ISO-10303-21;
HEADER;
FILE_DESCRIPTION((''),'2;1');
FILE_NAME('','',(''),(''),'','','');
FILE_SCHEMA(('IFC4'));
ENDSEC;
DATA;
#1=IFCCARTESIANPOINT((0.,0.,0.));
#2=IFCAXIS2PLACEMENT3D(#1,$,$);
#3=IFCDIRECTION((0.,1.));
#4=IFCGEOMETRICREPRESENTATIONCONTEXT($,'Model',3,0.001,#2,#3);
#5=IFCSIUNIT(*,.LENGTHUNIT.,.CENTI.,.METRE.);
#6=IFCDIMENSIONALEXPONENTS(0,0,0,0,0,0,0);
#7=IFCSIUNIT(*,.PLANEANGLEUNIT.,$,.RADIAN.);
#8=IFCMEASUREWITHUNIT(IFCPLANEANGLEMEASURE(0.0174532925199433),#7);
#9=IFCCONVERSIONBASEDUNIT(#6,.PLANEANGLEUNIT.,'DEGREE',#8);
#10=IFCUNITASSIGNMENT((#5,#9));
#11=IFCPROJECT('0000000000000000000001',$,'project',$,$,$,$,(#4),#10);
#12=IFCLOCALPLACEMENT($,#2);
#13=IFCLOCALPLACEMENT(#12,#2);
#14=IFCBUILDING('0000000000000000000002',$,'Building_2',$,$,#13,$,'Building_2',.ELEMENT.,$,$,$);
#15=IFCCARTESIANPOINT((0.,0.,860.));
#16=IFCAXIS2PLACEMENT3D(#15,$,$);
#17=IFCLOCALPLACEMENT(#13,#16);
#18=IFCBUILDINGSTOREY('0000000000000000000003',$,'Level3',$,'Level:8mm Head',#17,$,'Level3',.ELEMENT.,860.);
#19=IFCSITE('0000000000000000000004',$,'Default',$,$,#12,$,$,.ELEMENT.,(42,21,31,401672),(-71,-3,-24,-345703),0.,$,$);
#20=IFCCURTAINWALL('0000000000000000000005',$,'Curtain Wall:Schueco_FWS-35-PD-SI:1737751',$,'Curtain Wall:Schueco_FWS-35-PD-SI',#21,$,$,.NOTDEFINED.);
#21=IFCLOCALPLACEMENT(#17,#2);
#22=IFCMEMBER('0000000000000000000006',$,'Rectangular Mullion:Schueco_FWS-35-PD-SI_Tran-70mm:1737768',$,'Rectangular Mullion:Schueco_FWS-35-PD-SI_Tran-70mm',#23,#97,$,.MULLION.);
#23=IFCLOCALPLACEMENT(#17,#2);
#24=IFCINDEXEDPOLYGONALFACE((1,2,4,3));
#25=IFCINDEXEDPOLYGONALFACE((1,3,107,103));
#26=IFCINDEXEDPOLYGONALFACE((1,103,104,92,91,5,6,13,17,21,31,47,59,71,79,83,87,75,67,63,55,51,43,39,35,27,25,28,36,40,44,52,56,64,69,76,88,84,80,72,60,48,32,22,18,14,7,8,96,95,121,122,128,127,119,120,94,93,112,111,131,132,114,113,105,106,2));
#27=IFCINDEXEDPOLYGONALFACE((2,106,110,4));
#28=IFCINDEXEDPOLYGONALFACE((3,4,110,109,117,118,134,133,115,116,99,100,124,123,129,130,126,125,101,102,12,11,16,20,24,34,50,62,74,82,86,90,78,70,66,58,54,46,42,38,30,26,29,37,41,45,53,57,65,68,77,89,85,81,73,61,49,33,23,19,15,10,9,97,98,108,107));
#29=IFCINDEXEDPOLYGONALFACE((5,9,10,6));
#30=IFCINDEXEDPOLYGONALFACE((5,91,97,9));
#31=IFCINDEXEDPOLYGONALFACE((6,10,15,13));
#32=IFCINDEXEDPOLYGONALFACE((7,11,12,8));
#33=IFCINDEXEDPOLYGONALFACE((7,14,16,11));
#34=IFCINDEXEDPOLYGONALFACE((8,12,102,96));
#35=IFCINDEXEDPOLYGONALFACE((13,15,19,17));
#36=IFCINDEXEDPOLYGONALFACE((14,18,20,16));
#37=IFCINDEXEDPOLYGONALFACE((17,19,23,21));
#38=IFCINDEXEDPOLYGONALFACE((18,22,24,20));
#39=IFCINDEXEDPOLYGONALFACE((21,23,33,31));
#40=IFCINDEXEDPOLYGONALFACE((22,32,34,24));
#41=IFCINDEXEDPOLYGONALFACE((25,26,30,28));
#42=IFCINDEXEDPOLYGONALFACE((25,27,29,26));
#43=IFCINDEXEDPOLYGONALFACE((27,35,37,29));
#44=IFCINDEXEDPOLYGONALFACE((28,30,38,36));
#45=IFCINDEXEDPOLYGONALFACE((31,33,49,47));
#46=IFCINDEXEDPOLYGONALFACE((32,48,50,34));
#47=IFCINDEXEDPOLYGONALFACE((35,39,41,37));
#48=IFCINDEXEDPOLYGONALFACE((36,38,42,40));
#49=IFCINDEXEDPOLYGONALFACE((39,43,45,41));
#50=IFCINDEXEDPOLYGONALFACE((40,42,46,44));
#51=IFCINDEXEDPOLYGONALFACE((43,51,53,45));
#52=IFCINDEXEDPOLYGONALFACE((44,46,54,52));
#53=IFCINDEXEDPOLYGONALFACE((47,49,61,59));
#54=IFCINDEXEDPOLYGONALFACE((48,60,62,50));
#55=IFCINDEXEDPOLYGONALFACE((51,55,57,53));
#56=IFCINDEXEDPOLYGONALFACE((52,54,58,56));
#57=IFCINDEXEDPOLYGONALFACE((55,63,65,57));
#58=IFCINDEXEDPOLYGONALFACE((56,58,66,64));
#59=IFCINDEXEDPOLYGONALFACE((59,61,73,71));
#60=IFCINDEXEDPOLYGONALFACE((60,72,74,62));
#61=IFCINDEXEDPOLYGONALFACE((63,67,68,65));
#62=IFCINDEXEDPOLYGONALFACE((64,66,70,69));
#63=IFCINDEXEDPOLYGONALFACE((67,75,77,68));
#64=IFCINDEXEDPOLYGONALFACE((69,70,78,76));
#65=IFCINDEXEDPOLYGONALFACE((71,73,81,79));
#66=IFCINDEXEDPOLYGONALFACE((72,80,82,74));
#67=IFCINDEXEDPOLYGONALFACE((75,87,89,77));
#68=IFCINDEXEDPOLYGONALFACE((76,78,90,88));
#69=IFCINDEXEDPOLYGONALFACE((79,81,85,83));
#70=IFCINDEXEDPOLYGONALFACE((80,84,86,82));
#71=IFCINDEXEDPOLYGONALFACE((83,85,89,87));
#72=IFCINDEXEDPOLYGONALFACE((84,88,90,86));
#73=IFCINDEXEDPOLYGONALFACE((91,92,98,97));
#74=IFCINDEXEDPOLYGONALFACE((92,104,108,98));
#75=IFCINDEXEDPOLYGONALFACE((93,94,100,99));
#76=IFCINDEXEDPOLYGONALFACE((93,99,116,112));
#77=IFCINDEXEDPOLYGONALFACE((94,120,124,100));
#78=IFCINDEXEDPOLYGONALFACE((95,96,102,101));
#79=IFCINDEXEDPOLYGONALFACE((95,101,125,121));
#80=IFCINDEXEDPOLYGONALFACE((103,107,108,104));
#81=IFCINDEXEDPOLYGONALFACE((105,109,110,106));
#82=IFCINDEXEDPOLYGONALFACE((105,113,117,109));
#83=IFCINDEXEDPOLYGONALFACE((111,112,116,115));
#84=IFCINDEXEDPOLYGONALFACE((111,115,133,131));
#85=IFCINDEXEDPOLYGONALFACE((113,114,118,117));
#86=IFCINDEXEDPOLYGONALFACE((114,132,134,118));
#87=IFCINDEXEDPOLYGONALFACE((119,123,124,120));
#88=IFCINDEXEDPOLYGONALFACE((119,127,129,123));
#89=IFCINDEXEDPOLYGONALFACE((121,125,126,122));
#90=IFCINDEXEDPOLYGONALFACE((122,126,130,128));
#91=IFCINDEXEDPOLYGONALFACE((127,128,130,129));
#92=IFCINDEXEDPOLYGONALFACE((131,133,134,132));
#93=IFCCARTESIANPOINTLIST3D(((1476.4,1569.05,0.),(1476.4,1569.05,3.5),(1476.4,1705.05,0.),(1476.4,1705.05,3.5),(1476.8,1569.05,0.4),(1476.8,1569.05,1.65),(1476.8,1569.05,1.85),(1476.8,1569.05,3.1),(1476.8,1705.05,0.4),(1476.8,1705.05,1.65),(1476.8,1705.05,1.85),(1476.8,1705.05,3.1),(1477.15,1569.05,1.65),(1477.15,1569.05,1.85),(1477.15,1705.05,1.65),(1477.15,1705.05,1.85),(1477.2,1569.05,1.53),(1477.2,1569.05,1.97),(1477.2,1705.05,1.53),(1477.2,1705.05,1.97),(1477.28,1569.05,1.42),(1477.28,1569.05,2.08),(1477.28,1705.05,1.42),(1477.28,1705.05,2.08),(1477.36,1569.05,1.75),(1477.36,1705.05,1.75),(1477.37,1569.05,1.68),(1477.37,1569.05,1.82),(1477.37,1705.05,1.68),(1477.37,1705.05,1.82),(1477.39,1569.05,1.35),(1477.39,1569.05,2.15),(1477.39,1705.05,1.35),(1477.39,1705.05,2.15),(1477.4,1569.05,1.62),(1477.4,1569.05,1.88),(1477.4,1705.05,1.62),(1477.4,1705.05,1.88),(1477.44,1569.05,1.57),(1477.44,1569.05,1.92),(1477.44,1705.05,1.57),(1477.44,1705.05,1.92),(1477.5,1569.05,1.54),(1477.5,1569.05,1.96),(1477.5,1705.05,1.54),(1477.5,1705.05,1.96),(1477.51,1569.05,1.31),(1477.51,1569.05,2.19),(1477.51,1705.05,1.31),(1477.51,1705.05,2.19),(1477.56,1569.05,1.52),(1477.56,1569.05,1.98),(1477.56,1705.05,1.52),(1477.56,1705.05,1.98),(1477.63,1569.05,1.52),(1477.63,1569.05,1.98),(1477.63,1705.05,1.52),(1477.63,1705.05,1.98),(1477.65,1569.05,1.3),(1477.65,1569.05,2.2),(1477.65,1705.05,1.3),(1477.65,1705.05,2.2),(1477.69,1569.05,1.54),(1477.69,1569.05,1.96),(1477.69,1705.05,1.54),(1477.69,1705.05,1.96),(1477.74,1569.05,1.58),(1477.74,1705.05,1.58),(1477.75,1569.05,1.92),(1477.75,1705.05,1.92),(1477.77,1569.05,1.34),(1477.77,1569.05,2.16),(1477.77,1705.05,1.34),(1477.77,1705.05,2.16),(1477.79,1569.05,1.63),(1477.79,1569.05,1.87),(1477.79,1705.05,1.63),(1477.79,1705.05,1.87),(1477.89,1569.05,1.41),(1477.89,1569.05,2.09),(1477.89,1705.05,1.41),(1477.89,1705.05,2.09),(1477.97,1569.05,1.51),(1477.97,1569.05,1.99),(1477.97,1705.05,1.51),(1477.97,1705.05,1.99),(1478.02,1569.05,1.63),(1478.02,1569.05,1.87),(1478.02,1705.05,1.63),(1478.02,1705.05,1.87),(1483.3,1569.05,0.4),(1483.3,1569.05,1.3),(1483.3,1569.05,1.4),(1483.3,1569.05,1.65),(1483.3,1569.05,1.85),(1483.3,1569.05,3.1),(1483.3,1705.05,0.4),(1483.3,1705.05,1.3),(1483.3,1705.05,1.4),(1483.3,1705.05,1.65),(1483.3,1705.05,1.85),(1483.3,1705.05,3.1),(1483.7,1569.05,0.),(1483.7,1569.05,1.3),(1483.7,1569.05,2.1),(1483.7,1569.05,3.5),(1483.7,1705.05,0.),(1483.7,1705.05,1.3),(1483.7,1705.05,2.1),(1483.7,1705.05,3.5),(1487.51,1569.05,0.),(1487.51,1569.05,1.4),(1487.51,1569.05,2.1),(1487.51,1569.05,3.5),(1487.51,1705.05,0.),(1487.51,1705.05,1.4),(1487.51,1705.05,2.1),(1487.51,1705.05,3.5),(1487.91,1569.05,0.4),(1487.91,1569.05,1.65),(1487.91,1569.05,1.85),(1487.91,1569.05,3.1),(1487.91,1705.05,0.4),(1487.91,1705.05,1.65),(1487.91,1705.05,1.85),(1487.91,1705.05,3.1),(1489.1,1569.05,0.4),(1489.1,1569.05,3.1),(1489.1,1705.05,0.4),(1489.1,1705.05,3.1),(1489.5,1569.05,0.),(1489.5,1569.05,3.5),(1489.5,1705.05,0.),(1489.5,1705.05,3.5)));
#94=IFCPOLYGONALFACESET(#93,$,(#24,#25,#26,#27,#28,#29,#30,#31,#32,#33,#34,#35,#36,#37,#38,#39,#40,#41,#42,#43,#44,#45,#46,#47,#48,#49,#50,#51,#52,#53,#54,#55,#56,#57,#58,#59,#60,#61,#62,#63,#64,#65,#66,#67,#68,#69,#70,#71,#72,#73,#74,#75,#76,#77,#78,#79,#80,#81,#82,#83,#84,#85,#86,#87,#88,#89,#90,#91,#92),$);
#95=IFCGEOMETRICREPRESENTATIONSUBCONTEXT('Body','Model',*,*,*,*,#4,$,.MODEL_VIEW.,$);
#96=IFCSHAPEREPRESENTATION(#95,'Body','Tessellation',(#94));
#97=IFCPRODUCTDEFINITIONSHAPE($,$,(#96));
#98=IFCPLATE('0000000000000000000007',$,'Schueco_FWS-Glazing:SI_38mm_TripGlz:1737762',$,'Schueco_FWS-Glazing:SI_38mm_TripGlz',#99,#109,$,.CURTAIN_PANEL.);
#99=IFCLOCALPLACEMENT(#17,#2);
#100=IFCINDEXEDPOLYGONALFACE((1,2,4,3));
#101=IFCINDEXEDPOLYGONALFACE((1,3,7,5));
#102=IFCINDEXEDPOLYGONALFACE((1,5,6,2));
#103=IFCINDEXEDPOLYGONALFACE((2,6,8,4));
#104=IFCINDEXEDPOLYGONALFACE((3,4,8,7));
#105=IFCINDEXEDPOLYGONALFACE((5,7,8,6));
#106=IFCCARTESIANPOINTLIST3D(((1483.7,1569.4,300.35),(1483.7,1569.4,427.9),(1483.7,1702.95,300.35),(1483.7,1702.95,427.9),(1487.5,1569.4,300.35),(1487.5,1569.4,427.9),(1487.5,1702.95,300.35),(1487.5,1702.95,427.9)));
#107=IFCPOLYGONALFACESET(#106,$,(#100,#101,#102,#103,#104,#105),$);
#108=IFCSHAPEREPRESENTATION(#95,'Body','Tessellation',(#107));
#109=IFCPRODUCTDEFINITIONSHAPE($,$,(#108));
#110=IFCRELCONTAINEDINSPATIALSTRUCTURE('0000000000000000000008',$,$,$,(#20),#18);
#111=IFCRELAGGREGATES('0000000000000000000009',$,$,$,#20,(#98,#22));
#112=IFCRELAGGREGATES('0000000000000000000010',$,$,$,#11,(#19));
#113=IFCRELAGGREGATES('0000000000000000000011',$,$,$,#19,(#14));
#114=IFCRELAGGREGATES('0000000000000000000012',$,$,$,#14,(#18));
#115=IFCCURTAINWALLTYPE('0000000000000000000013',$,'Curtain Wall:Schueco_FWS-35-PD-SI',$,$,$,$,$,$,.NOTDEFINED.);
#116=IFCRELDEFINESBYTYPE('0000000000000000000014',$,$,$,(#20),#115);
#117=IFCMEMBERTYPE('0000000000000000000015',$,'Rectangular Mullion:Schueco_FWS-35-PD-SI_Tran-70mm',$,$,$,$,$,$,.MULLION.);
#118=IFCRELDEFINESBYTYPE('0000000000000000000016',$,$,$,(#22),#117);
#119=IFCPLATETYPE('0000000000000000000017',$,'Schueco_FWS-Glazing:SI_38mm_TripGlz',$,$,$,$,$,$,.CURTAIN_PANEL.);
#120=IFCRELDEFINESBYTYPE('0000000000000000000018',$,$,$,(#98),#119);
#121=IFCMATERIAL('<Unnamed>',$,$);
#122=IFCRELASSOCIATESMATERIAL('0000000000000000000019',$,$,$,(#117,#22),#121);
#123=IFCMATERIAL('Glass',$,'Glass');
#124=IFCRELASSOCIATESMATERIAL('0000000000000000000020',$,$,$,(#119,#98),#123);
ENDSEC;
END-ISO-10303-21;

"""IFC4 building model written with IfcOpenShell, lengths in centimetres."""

from ifc_helpers import new_model, entity, si_unit, converted_unit, direction, frame, origin, place, context, subcontext, project, spatial, line, arc, indexed_curve, outline, extrude, source, transform, mapped, material, type_object, type_shapes, element, aggregate, save


model = new_model("IFC4")

# Units and contexts
model_context = context("Model", 3, precision=0.001, world=origin(), true_north=direction((0.0, 1.0)))
body_context = subcontext(model_context, "Body", "Model", "MODEL_VIEW")
ifc_project = project(units=[si_unit("LENGTHUNIT", "METRE", prefix="CENTI"), converted_unit("PLANEANGLEUNIT", "DEGREE", entity("IfcPlaneAngleMeasure", 0.0174532925199433), si_unit("PLANEANGLEUNIT", "RADIAN"), dimensions=[0, 0, 0, 0, 0, 0, 0])], contexts=[model_context])

# Site, building, storey
site_placement = place(None, origin())
site = spatial("IfcSite", under=ifc_project, at=site_placement, Name="Default", CompositionType="ELEMENT", RefLatitude=(42, 21, 31, 401672), RefLongitude=(-71, -3, -24, -345703), RefElevation=0.0)
building_placement = place(site_placement, origin())
building = spatial("IfcBuilding", under=site, at=building_placement, Name="Building_2", LongName="Building_2", CompositionType="ELEMENT")
storey_placement = place(building_placement, frame((0.0, 0.0, 860.0)))
storey = spatial("IfcBuildingStorey", under=building, at=storey_placement, Name="Level3", ObjectType="Level:8mm Head", LongName="Level3", CompositionType="ELEMENT", Elevation=860.0)

# Curtain wall, member, plate
curtain_wall_type = type_object("IfcCurtainWallType", Name="Curtain Wall:Schueco_FWS-35-PD-SI", PredefinedType="NOTDEFINED")
curtain_wall_placement = place(storey_placement, frame((0.0, 0.0, -860.0)))
curtain_wall = element("IfcCurtainWall", 1, at=curtain_wall_placement, inside=storey, type_object=curtain_wall_type, Name="Curtain Wall:Schueco_FWS-35-PD-SI:1737751", ObjectType="Curtain Wall:Schueco_FWS-35-PD-SI", PredefinedType="NOTDEFINED")
ifc_material_1 = material(Name="<Unnamed>")
member_type_1 = type_object("IfcMemberType", Name="Rectangular Mullion:Schueco_FWS-35-PD-SI_Tran-70mm", PredefinedType="MULLION", material=ifc_material_1)
shared_shape_1 = source(origin(), body_context, "Body", "SweptSolid", [
    extrude(outline(indexed_curve([(-6.52, -1.78), (0.78, -1.78), (0.78, -0.38), (4.59, -0.38), (4.59, -1.78), (6.58, -1.78), (6.58, 1.72), (4.59, 1.72), (4.59, 0.32), (0.38, 0.32), (0.38, 0.07), (4.99, 0.07), (4.99, 1.32), (6.18, 1.32), (6.18, -1.38), (4.99, -1.38), (4.99, -0.13), (0.38, -0.13), (0.38, -1.38), (-6.12, -1.38), (-6.12, -0.13), (-5.77, -0.13), (-5.34, -0.48), (-4.9, -0.15), (-5.14, -0.15), (-5.56, -0.03), (-5.14, 0.09), (-4.9, 0.09), (-5.34, 0.42), (-5.77, 0.07), (-6.12, 0.07), (-6.12, 1.32), (0.38, 1.32), (0.38, 0.42), (0.78, 0.42), (0.78, 1.72), (-6.52, 1.72)], segments=[line(1, 2, 3, 4, 5, 6, 7, 8, 9, 10, 11, 12, 13, 14, 15, 16, 17, 18, 19, 20, 21, 22), arc(22, 23, 24), line(24, 25), arc(25, 26, 27), line(27, 28), arc(28, 29, 30), line(30, 31, 32, 33, 34, 35, 36, 37, 1)], self_intersect=False)), frame((-1.72, 4.58, -136.0), z_axis=(0.0, 0.0, 1.0), x_axis=(0.0, -1.0, 0.0)), (0.0, 0.0, 1.0), 136.0),
])
type_shapes(member_type_1, [shared_shape_1])
member_1_placement = place(curtain_wall_placement, frame((1487.5, 1705.05, 860.0), z_axis=(0.0, 1.0, 0.0), x_axis=(0.0, 0.0, -1.0)))
member_1 = element("IfcMember", 2, at=member_1_placement, type_object=member_type_1, material=ifc_material_1, Name="Rectangular Mullion:Schueco_FWS-35-PD-SI_Tran-70mm:1737768", ObjectType="Rectangular Mullion:Schueco_FWS-35-PD-SI_Tran-70mm", PredefinedType="MULLION", context=body_context, shape_type="MappedRepresentation", body=[
    mapped(shared_shape_1, transform((0.0, 0.0, 0.0), scale=1.0)),
])
ifc_material_2 = material(Name="Glass", Category="Glass")
plate_type = type_object("IfcPlateType", Name="Schueco_FWS-Glazing:SI_38mm_TripGlz", PredefinedType="CURTAIN_PANEL", material=ifc_material_2)
shared_shape_2 = source(origin(), body_context, "Body", "SweptSolid", [
    extrude(outline(indexed_curve([(-1.9, -66.78), (1.9, -66.78), (1.9, 66.78), (-1.9, 66.78), (-1.9, -66.78)], self_intersect=False)), frame((0.0, -1.9, 0.0), z_axis=(0.0, 0.0, 1.0), x_axis=(0.0, 1.0, 0.0)), (0.0, 0.0, 1.0), 127.55),
])
type_shapes(plate_type, [shared_shape_2])
plate_placement = place(curtain_wall_placement, frame((1487.5, 1636.17, 1160.35), z_axis=(0.0, 0.0, 1.0), x_axis=(0.0, -1.0, 0.0)))
plate = element("IfcPlate", 3, at=plate_placement, type_object=plate_type, material=ifc_material_2, Name="Schueco_FWS-Glazing:SI_38mm_TripGlz:1737762", ObjectType="Schueco_FWS-Glazing:SI_38mm_TripGlz", PredefinedType="CURTAIN_PANEL", context=body_context, shape_type="MappedRepresentation", body=[
    mapped(shared_shape_2, transform((0.0, 0.0, 0.0), scale=1.0)),
])
aggregate(curtain_wall, [plate, member_1])

save(model, "model.ifc")
